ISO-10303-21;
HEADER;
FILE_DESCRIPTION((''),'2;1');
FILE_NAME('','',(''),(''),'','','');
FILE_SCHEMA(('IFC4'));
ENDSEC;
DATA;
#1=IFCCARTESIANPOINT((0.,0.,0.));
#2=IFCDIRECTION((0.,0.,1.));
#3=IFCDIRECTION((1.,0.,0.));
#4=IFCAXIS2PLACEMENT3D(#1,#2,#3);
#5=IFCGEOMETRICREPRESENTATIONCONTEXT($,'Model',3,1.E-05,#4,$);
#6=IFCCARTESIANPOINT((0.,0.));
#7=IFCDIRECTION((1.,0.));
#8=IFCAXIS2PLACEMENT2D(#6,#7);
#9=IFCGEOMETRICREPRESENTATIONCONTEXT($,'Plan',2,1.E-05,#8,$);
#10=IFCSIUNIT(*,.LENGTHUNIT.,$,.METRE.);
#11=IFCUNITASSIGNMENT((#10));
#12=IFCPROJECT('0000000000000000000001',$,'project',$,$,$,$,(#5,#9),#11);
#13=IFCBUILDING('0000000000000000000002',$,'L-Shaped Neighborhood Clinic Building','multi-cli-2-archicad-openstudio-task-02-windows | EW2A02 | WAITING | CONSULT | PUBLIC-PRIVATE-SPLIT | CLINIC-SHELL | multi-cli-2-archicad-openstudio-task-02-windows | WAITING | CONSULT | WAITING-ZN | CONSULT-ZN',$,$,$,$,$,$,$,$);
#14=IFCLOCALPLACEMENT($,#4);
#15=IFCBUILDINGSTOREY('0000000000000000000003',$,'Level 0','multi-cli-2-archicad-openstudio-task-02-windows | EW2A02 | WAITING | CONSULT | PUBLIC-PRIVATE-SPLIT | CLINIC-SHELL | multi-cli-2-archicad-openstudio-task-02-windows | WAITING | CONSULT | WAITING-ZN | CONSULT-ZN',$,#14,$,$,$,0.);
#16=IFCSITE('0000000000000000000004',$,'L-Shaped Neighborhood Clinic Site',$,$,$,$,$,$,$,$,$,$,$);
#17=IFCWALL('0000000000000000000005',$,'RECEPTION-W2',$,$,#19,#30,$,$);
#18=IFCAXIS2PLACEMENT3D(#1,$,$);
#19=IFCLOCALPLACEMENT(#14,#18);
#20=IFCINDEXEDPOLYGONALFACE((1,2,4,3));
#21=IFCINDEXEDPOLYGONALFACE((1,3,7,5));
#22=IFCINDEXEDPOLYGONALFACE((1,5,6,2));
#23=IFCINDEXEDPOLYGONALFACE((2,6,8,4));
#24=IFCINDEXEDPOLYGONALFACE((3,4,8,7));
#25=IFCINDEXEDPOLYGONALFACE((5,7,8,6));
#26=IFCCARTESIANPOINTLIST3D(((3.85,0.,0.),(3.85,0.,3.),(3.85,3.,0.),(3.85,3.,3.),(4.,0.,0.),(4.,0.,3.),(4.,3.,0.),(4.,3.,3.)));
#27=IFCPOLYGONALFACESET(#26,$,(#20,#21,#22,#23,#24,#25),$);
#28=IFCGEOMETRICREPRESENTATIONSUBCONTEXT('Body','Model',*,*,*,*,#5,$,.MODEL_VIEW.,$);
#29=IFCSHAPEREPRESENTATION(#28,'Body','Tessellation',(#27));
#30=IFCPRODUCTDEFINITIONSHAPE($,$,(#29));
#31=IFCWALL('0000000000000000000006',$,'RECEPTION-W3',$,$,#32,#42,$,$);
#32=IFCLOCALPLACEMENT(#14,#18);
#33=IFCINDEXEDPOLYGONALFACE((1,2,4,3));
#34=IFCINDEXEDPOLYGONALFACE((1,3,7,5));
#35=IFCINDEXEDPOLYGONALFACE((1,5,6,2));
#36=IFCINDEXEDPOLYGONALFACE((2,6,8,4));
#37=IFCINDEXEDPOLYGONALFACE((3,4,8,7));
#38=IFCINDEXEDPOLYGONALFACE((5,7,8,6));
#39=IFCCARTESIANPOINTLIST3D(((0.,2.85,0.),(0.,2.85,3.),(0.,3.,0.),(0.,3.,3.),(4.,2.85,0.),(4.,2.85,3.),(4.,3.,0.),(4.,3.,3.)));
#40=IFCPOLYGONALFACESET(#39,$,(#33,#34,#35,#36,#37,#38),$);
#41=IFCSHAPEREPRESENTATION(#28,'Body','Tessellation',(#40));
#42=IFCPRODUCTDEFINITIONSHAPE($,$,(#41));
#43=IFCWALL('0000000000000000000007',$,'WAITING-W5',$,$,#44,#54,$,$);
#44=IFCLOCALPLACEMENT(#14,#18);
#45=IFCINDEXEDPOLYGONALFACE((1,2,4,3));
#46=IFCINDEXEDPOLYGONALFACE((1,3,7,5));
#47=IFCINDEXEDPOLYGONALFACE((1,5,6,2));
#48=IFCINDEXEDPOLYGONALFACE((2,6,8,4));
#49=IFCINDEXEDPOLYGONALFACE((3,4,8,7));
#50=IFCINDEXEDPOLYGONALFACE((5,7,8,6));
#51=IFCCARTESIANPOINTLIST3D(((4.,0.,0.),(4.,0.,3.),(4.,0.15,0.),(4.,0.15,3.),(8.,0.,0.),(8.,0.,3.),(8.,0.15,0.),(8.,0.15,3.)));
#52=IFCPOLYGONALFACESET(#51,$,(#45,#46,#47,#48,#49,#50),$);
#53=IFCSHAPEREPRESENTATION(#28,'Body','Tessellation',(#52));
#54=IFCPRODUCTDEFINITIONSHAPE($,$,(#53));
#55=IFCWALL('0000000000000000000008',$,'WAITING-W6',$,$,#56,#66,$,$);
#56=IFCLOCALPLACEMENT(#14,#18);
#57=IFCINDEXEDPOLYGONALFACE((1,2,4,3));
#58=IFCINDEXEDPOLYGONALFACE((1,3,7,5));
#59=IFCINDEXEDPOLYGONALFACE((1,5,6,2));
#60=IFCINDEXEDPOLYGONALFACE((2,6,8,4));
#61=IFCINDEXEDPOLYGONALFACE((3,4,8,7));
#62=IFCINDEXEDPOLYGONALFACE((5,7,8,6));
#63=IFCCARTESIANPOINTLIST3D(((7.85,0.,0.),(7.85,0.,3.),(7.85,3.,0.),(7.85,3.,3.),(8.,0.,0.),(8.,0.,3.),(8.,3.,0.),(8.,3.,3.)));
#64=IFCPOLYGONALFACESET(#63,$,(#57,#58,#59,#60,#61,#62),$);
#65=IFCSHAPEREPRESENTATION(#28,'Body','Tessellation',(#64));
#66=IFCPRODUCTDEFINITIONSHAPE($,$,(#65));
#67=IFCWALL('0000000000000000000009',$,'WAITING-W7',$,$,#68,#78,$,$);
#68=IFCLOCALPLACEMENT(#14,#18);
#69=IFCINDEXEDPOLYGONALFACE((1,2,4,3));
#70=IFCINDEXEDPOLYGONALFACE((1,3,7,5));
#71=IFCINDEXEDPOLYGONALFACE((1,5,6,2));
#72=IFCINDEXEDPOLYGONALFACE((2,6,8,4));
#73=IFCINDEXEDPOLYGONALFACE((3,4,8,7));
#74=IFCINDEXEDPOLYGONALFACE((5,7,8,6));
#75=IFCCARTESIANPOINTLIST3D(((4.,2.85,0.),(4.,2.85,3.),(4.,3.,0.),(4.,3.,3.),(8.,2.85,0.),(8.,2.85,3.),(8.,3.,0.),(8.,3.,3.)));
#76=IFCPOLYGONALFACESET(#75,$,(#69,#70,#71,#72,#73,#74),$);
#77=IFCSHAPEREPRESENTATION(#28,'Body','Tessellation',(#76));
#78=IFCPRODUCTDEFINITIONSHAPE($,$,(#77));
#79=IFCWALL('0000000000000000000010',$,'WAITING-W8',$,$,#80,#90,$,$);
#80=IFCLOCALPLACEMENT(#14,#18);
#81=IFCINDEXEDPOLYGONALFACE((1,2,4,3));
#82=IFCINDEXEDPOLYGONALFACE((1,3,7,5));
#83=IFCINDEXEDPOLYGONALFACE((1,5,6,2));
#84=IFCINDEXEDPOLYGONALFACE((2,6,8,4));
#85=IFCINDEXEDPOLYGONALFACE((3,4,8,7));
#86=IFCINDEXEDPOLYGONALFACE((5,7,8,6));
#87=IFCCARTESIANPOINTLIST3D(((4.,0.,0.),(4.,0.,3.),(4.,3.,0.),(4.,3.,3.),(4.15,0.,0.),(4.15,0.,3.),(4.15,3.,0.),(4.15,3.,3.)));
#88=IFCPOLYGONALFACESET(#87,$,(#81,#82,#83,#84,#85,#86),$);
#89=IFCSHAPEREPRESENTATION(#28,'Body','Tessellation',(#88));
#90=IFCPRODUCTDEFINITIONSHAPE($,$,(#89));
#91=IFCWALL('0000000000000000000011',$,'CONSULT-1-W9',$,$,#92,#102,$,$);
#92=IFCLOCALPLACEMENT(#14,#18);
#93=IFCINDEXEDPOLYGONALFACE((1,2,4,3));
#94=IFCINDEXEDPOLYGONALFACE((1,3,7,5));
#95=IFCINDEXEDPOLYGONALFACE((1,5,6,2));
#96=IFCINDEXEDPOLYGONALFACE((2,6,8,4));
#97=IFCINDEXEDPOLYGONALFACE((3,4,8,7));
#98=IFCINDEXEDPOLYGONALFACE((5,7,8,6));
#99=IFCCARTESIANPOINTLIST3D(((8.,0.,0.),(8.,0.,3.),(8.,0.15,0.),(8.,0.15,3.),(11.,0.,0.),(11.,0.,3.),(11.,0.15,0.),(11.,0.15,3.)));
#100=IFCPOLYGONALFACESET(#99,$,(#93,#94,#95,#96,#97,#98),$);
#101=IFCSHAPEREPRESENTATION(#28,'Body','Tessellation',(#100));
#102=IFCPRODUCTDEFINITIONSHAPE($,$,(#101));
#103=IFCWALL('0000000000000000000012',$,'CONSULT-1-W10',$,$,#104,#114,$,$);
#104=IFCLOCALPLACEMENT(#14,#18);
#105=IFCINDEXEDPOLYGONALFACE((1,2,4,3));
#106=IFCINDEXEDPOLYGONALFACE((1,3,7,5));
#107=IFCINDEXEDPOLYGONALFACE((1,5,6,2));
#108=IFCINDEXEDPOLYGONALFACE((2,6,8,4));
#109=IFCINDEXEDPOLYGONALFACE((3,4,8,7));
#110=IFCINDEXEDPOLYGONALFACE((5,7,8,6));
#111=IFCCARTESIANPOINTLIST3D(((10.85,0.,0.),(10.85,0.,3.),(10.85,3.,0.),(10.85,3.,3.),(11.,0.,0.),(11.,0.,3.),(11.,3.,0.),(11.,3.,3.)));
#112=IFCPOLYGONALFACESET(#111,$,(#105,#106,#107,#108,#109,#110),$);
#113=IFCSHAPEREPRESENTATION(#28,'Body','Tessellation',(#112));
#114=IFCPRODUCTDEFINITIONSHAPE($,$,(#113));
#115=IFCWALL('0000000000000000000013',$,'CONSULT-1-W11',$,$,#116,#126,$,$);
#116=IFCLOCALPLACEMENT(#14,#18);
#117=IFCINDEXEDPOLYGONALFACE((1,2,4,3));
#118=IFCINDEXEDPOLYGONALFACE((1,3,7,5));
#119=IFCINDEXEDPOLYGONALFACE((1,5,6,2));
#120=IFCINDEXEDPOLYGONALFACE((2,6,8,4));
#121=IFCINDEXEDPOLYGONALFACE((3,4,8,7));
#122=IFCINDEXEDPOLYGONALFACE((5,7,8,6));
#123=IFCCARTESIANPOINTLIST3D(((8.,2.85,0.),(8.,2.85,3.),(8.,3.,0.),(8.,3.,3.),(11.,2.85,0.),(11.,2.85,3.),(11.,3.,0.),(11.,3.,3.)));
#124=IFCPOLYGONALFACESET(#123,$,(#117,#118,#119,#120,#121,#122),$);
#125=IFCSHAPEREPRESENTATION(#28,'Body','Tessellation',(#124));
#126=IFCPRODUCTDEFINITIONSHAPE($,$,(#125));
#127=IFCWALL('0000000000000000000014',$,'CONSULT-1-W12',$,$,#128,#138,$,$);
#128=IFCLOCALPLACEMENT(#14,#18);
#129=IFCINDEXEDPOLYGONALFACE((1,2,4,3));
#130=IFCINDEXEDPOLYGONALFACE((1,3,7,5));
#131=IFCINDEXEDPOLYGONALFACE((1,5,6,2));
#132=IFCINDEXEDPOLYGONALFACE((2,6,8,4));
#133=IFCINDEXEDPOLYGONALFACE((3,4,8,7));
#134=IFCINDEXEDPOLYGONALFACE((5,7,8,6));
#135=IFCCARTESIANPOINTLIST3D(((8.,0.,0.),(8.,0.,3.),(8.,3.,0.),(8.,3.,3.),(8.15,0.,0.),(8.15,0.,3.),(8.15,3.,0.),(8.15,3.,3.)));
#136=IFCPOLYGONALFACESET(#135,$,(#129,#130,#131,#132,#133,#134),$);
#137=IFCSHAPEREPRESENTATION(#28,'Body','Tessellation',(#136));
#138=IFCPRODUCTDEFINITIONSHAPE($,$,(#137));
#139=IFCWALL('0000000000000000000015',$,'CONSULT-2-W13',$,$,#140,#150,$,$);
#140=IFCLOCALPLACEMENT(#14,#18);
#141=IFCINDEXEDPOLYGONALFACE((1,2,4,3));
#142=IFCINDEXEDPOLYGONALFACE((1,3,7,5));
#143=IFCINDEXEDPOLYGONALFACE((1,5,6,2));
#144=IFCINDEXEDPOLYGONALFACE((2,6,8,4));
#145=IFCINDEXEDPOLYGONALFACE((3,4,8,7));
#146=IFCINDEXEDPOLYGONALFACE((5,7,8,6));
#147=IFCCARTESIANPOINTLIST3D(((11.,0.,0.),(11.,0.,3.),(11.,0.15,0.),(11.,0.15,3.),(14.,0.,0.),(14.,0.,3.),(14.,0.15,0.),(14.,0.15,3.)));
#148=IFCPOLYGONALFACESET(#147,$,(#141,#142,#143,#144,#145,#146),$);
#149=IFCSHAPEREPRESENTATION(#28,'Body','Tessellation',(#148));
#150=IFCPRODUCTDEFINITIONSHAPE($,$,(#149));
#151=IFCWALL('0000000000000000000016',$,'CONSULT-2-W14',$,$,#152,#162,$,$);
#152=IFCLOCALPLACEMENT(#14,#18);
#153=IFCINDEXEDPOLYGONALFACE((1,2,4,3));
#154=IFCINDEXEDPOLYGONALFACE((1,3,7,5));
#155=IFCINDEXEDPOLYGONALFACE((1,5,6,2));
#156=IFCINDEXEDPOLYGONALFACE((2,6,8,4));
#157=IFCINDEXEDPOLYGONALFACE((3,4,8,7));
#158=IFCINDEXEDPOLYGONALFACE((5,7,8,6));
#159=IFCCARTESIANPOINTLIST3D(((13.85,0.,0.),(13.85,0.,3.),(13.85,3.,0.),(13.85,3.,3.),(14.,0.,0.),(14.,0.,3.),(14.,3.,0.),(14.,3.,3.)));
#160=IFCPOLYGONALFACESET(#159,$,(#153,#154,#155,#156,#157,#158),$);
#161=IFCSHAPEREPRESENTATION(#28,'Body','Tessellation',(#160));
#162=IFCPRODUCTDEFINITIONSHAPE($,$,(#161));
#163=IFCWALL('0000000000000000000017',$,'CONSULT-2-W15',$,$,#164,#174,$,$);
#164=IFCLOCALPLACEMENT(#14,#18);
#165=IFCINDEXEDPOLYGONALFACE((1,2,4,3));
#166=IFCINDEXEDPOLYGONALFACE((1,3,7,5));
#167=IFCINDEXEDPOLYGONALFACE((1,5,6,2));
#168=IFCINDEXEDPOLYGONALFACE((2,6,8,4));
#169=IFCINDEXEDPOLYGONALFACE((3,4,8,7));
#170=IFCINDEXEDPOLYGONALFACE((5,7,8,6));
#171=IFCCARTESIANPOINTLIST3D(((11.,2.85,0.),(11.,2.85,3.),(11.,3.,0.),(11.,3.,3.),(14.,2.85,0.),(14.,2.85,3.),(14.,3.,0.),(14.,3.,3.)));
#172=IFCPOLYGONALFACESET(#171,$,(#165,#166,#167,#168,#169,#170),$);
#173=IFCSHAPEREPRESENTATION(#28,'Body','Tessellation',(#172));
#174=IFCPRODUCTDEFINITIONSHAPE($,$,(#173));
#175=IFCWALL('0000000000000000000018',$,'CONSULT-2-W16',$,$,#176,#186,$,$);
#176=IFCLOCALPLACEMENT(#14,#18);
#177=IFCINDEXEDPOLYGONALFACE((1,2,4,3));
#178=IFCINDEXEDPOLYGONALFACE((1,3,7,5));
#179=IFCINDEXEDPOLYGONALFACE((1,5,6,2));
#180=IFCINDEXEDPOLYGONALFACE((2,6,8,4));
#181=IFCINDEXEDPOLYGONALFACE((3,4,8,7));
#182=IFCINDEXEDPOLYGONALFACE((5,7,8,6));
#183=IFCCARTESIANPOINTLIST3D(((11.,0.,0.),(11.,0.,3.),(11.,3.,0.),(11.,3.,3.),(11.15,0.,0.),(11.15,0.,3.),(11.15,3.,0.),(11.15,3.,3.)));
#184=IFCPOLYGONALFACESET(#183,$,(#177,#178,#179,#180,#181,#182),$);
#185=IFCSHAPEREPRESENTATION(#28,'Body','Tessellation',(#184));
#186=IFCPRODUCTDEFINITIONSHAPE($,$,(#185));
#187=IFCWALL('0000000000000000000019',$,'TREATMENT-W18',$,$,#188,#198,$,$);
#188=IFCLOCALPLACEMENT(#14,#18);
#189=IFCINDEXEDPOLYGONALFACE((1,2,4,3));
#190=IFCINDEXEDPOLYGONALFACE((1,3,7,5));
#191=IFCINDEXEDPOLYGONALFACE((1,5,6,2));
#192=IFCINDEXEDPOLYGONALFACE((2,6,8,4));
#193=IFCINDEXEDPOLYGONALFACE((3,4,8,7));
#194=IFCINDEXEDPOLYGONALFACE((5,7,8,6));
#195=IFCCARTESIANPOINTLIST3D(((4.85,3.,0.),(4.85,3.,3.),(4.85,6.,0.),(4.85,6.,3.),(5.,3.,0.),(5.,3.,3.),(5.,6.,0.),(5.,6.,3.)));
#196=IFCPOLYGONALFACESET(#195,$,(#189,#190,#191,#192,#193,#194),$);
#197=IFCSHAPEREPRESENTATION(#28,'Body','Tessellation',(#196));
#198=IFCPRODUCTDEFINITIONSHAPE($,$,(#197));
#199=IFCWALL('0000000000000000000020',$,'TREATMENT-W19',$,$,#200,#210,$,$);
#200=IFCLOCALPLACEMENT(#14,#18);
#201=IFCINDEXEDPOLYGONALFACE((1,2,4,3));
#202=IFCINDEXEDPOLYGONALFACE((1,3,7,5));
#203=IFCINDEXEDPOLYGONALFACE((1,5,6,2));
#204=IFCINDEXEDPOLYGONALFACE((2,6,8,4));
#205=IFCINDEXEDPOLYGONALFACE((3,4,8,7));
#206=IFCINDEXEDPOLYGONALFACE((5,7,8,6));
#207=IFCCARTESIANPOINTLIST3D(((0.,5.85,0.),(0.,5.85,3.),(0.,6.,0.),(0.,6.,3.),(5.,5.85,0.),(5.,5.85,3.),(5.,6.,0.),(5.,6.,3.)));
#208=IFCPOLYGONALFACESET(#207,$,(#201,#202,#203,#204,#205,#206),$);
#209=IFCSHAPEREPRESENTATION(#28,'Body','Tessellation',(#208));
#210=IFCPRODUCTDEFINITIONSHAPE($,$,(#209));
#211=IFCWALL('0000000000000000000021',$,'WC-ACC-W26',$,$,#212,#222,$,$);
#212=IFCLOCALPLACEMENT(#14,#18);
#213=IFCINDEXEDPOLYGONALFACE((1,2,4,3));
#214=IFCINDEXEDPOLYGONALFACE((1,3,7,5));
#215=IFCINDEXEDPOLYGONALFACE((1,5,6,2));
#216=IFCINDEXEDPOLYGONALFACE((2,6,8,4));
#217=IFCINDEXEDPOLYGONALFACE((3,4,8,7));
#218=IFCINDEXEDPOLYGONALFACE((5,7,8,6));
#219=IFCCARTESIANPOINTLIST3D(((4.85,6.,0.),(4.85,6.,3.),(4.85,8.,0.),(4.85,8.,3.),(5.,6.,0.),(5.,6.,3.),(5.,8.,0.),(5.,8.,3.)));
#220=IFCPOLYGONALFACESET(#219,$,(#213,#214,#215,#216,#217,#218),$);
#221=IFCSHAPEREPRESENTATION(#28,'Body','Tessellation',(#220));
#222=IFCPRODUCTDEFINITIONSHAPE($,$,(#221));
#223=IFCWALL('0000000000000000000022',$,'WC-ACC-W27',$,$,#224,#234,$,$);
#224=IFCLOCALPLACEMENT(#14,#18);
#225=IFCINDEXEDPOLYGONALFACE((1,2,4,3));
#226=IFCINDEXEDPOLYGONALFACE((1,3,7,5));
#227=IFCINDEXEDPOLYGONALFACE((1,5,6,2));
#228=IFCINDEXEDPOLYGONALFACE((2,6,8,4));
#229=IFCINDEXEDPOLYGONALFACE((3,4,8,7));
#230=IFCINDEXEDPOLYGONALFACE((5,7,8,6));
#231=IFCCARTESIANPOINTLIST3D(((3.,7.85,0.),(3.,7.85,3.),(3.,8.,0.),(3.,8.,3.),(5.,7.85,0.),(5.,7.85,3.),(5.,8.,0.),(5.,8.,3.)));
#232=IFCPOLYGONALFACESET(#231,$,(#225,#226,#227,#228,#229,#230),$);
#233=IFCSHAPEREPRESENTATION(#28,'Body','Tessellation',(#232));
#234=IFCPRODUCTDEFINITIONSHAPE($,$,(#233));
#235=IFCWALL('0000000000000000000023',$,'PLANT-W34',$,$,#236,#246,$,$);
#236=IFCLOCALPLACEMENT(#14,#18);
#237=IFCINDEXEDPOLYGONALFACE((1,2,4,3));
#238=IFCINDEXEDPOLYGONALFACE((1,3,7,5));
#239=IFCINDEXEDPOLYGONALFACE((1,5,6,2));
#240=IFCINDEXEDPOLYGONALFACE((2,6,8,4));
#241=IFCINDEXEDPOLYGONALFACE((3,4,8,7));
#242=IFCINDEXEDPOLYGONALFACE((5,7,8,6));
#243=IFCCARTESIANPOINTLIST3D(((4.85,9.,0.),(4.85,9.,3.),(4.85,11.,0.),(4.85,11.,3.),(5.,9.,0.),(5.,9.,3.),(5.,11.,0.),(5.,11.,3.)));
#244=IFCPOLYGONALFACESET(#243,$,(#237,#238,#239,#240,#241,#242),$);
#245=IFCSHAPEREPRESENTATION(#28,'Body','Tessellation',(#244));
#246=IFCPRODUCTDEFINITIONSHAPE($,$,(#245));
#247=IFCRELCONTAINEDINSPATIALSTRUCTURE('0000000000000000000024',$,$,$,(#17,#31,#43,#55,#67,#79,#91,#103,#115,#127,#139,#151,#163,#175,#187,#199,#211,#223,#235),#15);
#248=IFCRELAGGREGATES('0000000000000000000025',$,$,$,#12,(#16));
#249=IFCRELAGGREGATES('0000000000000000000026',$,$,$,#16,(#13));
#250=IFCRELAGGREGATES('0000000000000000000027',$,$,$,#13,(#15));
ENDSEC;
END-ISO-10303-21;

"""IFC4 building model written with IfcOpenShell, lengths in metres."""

from ifc_helpers import new_model, si_unit, frame, origin_with_axes, origin_2d_with_axis, place, context, subcontext, project, spatial, indexed_curve, outline, extrude, element, save


model = new_model("IFC4")

# Units and contexts
model_context = context("Model", 3, precision=1e-05, world=origin_with_axes())
plan_context = context("Plan", 2, precision=1e-05, world=origin_2d_with_axis())
body_context = subcontext(model_context, "Body", "Model", "MODEL_VIEW")
ifc_project = project(units=[si_unit("LENGTHUNIT", "METRE")], contexts=[model_context, plan_context])

# Site, building, storey
site = spatial("IfcSite", under=ifc_project, Name="L-Shaped Neighborhood Clinic Site")
building = spatial("IfcBuilding", under=site, Name="L-Shaped Neighborhood Clinic Building", Description="multi-cli-2-archicad-openstudio-task-02-windows | EW2A02 | WAITING | CONSULT | PUBLIC-PRIVATE-SPLIT | CLINIC-SHELL | multi-cli-2-archicad-openstudio-task-02-windows | WAITING | CONSULT | WAITING-ZN | CONSULT-ZN")
storey_placement = place(None, origin_with_axes())
storey = spatial("IfcBuildingStorey", under=building, at=storey_placement, Name="Level 0", Description="multi-cli-2-archicad-openstudio-task-02-windows | EW2A02 | WAITING | CONSULT | PUBLIC-PRIVATE-SPLIT | CLINIC-SHELL | multi-cli-2-archicad-openstudio-task-02-windows | WAITING | CONSULT | WAITING-ZN | CONSULT-ZN", Elevation=0.0)

# Walls
wall_1_placement = place(storey_placement, frame((4.0, 0.0, 0.0), z_axis=(0.0, 0.0, 1.0), x_axis=(0.0, 1.0, 0.0)))
element("IfcWall", 1, at=wall_1_placement, inside=storey, Name="RECEPTION-W2", context=body_context, shape_type="SweptSolid", body=[
    extrude(outline(indexed_curve([(0.0, 0.0), (0.0, 0.15), (3.0, 0.15), (3.0, 0.0), (0.0, 0.0)], self_intersect=False)), origin_with_axes(), (0.0, 0.0, 1.0), 3.0),
])
for number, where, z_axis, x_axis, name in (
    (2, (4.0, 3.0, 0.0), (0.0, 0.0, 1.0), (-1.0, 0.0, 0.0), "RECEPTION-W3"),
    (3, (4.0, 0.0, 0.0), (0.0, 0.0, 1.0), (1.0, 0.0, 0.0), "WAITING-W5"),
):
    element("IfcWall", number, at=place(storey_placement, frame(where, z_axis=z_axis, x_axis=x_axis)), inside=storey, Name=name, context=body_context, shape_type="SweptSolid", body=[
        extrude(outline(indexed_curve([(0.0, 0.0), (0.0, 0.15), (4.0, 0.15), (4.0, 0.0), (0.0, 0.0)], self_intersect=False)), origin_with_axes(), (0.0, 0.0, 1.0), 3.0),
    ])
wall_2_placement = place(storey_placement, frame((8.0, 0.0, 0.0), z_axis=(0.0, 0.0, 1.0), x_axis=(0.0, 1.0, 0.0)))
element("IfcWall", 4, at=wall_2_placement, inside=storey, Name="WAITING-W6", context=body_context, shape_type="SweptSolid", body=[
    extrude(outline(indexed_curve([(0.0, 0.0), (0.0, 0.15), (3.0, 0.15), (3.0, 0.0), (0.0, 0.0)], self_intersect=False)), origin_with_axes(), (0.0, 0.0, 1.0), 3.0),
])
wall_3_placement = place(storey_placement, frame((8.0, 3.0, 0.0), z_axis=(0.0, 0.0, 1.0), x_axis=(-1.0, 0.0, 0.0)))
element("IfcWall", 5, at=wall_3_placement, inside=storey, Name="WAITING-W7", context=body_context, shape_type="SweptSolid", body=[
    extrude(outline(indexed_curve([(0.0, 0.0), (0.0, 0.15), (4.0, 0.15), (4.0, 0.0), (0.0, 0.0)], self_intersect=False)), origin_with_axes(), (0.0, 0.0, 1.0), 3.0),
])
for number, where, z_axis, x_axis, name in (
    (6, (4.0, 3.0, 0.0), (0.0, 0.0, 1.0), (0.0, -1.0, 0.0), "WAITING-W8"),
    (7, (8.0, 0.0, 0.0), (0.0, 0.0, 1.0), (1.0, 0.0, 0.0), "CONSULT-1-W9"),
    (8, (11.0, 0.0, 0.0), (0.0, 0.0, 1.0), (0.0, 1.0, 0.0), "CONSULT-1-W10"),
    (9, (11.0, 3.0, 0.0), (0.0, 0.0, 1.0), (-1.0, 0.0, 0.0), "CONSULT-1-W11"),
    (10, (8.0, 3.0, 0.0), (0.0, 0.0, 1.0), (0.0, -1.0, 0.0), "CONSULT-1-W12"),
    (11, (11.0, 0.0, 0.0), (0.0, 0.0, 1.0), (1.0, 0.0, 0.0), "CONSULT-2-W13"),
    (12, (14.0, 0.0, 0.0), (0.0, 0.0, 1.0), (0.0, 1.0, 0.0), "CONSULT-2-W14"),
    (13, (14.0, 3.0, 0.0), (0.0, 0.0, 1.0), (-1.0, 0.0, 0.0), "CONSULT-2-W15"),
    (14, (11.0, 3.0, 0.0), (0.0, 0.0, 1.0), (0.0, -1.0, 0.0), "CONSULT-2-W16"),
    (15, (5.0, 3.0, 0.0), (0.0, 0.0, 1.0), (0.0, 1.0, 0.0), "TREATMENT-W18"),
):
    element("IfcWall", number, at=place(storey_placement, frame(where, z_axis=z_axis, x_axis=x_axis)), inside=storey, Name=name, context=body_context, shape_type="SweptSolid", body=[
        extrude(outline(indexed_curve([(0.0, 0.0), (0.0, 0.15), (3.0, 0.15), (3.0, 0.0), (0.0, 0.0)], self_intersect=False)), origin_with_axes(), (0.0, 0.0, 1.0), 3.0),
    ])
wall_4_placement = place(storey_placement, frame((5.0, 6.0, 0.0), z_axis=(0.0, 0.0, 1.0), x_axis=(-1.0, 0.0, 0.0)))
element("IfcWall", 16, at=wall_4_placement, inside=storey, Name="TREATMENT-W19", context=body_context, shape_type="SweptSolid", body=[
    extrude(outline(indexed_curve([(0.0, 0.0), (0.0, 0.15), (5.0, 0.15), (5.0, 0.0), (0.0, 0.0)], self_intersect=False)), origin_with_axes(), (0.0, 0.0, 1.0), 3.0),
])
for number, where, z_axis, x_axis, name in (
    (17, (5.0, 6.0, 0.0), (0.0, 0.0, 1.0), (0.0, 1.0, 0.0), "WC-ACC-W26"),
    (18, (5.0, 8.0, 0.0), (0.0, 0.0, 1.0), (-1.0, 0.0, 0.0), "WC-ACC-W27"),
    (19, (5.0, 9.0, 0.0), (0.0, 0.0, 1.0), (0.0, 1.0, 0.0), "PLANT-W34"),
):
    element("IfcWall", number, at=place(storey_placement, frame(where, z_axis=z_axis, x_axis=x_axis)), inside=storey, Name=name, context=body_context, shape_type="SweptSolid", body=[
        extrude(outline(indexed_curve([(0.0, 0.0), (0.0, 0.15), (2.0, 0.15), (2.0, 0.0), (0.0, 0.0)], self_intersect=False)), origin_with_axes(), (0.0, 0.0, 1.0), 3.0),
    ])

save(model, "model.ifc")
